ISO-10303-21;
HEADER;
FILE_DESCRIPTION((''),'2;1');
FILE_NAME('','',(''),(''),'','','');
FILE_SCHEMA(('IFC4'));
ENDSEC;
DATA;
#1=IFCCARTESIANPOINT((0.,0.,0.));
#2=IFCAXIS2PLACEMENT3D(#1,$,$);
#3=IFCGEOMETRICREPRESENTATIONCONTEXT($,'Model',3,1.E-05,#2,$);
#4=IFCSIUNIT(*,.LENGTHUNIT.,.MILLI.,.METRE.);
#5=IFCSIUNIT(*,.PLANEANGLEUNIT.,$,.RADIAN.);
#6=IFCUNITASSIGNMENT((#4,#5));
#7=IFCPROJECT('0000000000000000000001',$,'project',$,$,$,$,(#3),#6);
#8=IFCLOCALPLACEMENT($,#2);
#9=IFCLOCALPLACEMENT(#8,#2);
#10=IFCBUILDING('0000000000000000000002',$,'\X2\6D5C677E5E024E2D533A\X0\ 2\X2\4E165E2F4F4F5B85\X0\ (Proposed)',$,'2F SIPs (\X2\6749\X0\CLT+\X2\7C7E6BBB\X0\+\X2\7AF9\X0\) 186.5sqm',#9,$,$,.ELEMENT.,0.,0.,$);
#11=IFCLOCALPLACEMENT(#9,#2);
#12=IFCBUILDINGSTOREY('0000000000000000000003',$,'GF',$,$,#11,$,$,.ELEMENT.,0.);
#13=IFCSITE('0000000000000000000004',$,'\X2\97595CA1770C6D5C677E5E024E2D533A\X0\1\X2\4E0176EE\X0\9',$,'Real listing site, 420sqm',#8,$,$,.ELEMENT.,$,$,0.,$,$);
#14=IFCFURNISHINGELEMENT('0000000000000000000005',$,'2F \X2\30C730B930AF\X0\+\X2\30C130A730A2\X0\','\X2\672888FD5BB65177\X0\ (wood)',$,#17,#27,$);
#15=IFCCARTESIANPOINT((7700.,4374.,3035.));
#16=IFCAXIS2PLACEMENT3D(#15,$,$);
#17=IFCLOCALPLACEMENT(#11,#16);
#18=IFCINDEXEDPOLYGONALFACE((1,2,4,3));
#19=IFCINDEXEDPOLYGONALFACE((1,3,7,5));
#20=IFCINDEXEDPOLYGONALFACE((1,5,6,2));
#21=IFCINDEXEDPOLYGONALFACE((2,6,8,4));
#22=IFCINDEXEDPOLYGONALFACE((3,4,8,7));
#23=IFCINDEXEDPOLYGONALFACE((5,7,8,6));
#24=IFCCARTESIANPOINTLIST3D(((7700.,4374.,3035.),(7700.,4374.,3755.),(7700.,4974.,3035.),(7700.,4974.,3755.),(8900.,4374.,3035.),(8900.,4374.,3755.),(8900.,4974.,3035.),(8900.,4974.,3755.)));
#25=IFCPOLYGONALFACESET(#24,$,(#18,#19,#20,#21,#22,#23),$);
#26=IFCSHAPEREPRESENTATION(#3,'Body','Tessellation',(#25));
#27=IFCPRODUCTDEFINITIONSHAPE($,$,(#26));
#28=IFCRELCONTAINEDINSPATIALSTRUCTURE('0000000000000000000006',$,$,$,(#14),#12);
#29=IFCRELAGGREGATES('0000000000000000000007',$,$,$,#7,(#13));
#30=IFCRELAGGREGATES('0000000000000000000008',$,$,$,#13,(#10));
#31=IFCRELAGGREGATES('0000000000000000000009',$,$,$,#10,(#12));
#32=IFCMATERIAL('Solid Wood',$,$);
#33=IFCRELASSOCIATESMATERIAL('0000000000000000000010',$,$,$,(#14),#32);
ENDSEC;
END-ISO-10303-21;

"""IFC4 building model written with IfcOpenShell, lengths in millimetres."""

from ifc_helpers import new_model, si_unit, frame, frame_2d, origin, place, context, project, spatial, rectangle, extrude, material, element, save


model = new_model("IFC4")

# Units and contexts
model_context = context("Model", 3, precision=1e-05, world=origin())
ifc_project = project(units=[si_unit("LENGTHUNIT", "METRE", prefix="MILLI"), si_unit("PLANEANGLEUNIT", "RADIAN")], contexts=[model_context])

# Site, building, storey
site_placement = place(None, origin())
site = spatial("IfcSite", under=ifc_project, at=site_placement, Name="静岡県浜松市中区1丁目9", ObjectType="Real listing site, 420sqm", CompositionType="ELEMENT", RefElevation=0.0)
building_placement = place(site_placement, origin())
building = spatial("IfcBuilding", under=site, at=building_placement, Name="浜松市中区 2世帯住宅 (Proposed)", ObjectType="2F SIPs (杉CLT+籾殻+竹) 186.5sqm", CompositionType="ELEMENT", ElevationOfRefHeight=0.0, ElevationOfTerrain=0.0)
storey_placement = place(building_placement, origin())
storey = spatial("IfcBuildingStorey", under=building, at=storey_placement, Name="GF", CompositionType="ELEMENT", Elevation=0.0)

# Shared definitions
ifc_material_1 = material(Name="Solid Wood")

# Furnishing element
furnishing_1_placement = place(storey_placement, frame((7700.0, 4374.0, 3035.0)))
element("IfcFurnishingElement", 1, at=furnishing_1_placement, inside=storey, material=ifc_material_1, Name="2F デスク+チェア", Description="木製家具 (wood)", context=model_context, shape_type="SweptSolid", body=[
    extrude(rectangle(XDim=1200.0, YDim=600.0, at=frame_2d((600.0, 300.0))), frame((7700.0, 4374.0, 3035.0)), (0.0, 0.0, 1.0), 720.0),
])

save(model, "model.ifc")
